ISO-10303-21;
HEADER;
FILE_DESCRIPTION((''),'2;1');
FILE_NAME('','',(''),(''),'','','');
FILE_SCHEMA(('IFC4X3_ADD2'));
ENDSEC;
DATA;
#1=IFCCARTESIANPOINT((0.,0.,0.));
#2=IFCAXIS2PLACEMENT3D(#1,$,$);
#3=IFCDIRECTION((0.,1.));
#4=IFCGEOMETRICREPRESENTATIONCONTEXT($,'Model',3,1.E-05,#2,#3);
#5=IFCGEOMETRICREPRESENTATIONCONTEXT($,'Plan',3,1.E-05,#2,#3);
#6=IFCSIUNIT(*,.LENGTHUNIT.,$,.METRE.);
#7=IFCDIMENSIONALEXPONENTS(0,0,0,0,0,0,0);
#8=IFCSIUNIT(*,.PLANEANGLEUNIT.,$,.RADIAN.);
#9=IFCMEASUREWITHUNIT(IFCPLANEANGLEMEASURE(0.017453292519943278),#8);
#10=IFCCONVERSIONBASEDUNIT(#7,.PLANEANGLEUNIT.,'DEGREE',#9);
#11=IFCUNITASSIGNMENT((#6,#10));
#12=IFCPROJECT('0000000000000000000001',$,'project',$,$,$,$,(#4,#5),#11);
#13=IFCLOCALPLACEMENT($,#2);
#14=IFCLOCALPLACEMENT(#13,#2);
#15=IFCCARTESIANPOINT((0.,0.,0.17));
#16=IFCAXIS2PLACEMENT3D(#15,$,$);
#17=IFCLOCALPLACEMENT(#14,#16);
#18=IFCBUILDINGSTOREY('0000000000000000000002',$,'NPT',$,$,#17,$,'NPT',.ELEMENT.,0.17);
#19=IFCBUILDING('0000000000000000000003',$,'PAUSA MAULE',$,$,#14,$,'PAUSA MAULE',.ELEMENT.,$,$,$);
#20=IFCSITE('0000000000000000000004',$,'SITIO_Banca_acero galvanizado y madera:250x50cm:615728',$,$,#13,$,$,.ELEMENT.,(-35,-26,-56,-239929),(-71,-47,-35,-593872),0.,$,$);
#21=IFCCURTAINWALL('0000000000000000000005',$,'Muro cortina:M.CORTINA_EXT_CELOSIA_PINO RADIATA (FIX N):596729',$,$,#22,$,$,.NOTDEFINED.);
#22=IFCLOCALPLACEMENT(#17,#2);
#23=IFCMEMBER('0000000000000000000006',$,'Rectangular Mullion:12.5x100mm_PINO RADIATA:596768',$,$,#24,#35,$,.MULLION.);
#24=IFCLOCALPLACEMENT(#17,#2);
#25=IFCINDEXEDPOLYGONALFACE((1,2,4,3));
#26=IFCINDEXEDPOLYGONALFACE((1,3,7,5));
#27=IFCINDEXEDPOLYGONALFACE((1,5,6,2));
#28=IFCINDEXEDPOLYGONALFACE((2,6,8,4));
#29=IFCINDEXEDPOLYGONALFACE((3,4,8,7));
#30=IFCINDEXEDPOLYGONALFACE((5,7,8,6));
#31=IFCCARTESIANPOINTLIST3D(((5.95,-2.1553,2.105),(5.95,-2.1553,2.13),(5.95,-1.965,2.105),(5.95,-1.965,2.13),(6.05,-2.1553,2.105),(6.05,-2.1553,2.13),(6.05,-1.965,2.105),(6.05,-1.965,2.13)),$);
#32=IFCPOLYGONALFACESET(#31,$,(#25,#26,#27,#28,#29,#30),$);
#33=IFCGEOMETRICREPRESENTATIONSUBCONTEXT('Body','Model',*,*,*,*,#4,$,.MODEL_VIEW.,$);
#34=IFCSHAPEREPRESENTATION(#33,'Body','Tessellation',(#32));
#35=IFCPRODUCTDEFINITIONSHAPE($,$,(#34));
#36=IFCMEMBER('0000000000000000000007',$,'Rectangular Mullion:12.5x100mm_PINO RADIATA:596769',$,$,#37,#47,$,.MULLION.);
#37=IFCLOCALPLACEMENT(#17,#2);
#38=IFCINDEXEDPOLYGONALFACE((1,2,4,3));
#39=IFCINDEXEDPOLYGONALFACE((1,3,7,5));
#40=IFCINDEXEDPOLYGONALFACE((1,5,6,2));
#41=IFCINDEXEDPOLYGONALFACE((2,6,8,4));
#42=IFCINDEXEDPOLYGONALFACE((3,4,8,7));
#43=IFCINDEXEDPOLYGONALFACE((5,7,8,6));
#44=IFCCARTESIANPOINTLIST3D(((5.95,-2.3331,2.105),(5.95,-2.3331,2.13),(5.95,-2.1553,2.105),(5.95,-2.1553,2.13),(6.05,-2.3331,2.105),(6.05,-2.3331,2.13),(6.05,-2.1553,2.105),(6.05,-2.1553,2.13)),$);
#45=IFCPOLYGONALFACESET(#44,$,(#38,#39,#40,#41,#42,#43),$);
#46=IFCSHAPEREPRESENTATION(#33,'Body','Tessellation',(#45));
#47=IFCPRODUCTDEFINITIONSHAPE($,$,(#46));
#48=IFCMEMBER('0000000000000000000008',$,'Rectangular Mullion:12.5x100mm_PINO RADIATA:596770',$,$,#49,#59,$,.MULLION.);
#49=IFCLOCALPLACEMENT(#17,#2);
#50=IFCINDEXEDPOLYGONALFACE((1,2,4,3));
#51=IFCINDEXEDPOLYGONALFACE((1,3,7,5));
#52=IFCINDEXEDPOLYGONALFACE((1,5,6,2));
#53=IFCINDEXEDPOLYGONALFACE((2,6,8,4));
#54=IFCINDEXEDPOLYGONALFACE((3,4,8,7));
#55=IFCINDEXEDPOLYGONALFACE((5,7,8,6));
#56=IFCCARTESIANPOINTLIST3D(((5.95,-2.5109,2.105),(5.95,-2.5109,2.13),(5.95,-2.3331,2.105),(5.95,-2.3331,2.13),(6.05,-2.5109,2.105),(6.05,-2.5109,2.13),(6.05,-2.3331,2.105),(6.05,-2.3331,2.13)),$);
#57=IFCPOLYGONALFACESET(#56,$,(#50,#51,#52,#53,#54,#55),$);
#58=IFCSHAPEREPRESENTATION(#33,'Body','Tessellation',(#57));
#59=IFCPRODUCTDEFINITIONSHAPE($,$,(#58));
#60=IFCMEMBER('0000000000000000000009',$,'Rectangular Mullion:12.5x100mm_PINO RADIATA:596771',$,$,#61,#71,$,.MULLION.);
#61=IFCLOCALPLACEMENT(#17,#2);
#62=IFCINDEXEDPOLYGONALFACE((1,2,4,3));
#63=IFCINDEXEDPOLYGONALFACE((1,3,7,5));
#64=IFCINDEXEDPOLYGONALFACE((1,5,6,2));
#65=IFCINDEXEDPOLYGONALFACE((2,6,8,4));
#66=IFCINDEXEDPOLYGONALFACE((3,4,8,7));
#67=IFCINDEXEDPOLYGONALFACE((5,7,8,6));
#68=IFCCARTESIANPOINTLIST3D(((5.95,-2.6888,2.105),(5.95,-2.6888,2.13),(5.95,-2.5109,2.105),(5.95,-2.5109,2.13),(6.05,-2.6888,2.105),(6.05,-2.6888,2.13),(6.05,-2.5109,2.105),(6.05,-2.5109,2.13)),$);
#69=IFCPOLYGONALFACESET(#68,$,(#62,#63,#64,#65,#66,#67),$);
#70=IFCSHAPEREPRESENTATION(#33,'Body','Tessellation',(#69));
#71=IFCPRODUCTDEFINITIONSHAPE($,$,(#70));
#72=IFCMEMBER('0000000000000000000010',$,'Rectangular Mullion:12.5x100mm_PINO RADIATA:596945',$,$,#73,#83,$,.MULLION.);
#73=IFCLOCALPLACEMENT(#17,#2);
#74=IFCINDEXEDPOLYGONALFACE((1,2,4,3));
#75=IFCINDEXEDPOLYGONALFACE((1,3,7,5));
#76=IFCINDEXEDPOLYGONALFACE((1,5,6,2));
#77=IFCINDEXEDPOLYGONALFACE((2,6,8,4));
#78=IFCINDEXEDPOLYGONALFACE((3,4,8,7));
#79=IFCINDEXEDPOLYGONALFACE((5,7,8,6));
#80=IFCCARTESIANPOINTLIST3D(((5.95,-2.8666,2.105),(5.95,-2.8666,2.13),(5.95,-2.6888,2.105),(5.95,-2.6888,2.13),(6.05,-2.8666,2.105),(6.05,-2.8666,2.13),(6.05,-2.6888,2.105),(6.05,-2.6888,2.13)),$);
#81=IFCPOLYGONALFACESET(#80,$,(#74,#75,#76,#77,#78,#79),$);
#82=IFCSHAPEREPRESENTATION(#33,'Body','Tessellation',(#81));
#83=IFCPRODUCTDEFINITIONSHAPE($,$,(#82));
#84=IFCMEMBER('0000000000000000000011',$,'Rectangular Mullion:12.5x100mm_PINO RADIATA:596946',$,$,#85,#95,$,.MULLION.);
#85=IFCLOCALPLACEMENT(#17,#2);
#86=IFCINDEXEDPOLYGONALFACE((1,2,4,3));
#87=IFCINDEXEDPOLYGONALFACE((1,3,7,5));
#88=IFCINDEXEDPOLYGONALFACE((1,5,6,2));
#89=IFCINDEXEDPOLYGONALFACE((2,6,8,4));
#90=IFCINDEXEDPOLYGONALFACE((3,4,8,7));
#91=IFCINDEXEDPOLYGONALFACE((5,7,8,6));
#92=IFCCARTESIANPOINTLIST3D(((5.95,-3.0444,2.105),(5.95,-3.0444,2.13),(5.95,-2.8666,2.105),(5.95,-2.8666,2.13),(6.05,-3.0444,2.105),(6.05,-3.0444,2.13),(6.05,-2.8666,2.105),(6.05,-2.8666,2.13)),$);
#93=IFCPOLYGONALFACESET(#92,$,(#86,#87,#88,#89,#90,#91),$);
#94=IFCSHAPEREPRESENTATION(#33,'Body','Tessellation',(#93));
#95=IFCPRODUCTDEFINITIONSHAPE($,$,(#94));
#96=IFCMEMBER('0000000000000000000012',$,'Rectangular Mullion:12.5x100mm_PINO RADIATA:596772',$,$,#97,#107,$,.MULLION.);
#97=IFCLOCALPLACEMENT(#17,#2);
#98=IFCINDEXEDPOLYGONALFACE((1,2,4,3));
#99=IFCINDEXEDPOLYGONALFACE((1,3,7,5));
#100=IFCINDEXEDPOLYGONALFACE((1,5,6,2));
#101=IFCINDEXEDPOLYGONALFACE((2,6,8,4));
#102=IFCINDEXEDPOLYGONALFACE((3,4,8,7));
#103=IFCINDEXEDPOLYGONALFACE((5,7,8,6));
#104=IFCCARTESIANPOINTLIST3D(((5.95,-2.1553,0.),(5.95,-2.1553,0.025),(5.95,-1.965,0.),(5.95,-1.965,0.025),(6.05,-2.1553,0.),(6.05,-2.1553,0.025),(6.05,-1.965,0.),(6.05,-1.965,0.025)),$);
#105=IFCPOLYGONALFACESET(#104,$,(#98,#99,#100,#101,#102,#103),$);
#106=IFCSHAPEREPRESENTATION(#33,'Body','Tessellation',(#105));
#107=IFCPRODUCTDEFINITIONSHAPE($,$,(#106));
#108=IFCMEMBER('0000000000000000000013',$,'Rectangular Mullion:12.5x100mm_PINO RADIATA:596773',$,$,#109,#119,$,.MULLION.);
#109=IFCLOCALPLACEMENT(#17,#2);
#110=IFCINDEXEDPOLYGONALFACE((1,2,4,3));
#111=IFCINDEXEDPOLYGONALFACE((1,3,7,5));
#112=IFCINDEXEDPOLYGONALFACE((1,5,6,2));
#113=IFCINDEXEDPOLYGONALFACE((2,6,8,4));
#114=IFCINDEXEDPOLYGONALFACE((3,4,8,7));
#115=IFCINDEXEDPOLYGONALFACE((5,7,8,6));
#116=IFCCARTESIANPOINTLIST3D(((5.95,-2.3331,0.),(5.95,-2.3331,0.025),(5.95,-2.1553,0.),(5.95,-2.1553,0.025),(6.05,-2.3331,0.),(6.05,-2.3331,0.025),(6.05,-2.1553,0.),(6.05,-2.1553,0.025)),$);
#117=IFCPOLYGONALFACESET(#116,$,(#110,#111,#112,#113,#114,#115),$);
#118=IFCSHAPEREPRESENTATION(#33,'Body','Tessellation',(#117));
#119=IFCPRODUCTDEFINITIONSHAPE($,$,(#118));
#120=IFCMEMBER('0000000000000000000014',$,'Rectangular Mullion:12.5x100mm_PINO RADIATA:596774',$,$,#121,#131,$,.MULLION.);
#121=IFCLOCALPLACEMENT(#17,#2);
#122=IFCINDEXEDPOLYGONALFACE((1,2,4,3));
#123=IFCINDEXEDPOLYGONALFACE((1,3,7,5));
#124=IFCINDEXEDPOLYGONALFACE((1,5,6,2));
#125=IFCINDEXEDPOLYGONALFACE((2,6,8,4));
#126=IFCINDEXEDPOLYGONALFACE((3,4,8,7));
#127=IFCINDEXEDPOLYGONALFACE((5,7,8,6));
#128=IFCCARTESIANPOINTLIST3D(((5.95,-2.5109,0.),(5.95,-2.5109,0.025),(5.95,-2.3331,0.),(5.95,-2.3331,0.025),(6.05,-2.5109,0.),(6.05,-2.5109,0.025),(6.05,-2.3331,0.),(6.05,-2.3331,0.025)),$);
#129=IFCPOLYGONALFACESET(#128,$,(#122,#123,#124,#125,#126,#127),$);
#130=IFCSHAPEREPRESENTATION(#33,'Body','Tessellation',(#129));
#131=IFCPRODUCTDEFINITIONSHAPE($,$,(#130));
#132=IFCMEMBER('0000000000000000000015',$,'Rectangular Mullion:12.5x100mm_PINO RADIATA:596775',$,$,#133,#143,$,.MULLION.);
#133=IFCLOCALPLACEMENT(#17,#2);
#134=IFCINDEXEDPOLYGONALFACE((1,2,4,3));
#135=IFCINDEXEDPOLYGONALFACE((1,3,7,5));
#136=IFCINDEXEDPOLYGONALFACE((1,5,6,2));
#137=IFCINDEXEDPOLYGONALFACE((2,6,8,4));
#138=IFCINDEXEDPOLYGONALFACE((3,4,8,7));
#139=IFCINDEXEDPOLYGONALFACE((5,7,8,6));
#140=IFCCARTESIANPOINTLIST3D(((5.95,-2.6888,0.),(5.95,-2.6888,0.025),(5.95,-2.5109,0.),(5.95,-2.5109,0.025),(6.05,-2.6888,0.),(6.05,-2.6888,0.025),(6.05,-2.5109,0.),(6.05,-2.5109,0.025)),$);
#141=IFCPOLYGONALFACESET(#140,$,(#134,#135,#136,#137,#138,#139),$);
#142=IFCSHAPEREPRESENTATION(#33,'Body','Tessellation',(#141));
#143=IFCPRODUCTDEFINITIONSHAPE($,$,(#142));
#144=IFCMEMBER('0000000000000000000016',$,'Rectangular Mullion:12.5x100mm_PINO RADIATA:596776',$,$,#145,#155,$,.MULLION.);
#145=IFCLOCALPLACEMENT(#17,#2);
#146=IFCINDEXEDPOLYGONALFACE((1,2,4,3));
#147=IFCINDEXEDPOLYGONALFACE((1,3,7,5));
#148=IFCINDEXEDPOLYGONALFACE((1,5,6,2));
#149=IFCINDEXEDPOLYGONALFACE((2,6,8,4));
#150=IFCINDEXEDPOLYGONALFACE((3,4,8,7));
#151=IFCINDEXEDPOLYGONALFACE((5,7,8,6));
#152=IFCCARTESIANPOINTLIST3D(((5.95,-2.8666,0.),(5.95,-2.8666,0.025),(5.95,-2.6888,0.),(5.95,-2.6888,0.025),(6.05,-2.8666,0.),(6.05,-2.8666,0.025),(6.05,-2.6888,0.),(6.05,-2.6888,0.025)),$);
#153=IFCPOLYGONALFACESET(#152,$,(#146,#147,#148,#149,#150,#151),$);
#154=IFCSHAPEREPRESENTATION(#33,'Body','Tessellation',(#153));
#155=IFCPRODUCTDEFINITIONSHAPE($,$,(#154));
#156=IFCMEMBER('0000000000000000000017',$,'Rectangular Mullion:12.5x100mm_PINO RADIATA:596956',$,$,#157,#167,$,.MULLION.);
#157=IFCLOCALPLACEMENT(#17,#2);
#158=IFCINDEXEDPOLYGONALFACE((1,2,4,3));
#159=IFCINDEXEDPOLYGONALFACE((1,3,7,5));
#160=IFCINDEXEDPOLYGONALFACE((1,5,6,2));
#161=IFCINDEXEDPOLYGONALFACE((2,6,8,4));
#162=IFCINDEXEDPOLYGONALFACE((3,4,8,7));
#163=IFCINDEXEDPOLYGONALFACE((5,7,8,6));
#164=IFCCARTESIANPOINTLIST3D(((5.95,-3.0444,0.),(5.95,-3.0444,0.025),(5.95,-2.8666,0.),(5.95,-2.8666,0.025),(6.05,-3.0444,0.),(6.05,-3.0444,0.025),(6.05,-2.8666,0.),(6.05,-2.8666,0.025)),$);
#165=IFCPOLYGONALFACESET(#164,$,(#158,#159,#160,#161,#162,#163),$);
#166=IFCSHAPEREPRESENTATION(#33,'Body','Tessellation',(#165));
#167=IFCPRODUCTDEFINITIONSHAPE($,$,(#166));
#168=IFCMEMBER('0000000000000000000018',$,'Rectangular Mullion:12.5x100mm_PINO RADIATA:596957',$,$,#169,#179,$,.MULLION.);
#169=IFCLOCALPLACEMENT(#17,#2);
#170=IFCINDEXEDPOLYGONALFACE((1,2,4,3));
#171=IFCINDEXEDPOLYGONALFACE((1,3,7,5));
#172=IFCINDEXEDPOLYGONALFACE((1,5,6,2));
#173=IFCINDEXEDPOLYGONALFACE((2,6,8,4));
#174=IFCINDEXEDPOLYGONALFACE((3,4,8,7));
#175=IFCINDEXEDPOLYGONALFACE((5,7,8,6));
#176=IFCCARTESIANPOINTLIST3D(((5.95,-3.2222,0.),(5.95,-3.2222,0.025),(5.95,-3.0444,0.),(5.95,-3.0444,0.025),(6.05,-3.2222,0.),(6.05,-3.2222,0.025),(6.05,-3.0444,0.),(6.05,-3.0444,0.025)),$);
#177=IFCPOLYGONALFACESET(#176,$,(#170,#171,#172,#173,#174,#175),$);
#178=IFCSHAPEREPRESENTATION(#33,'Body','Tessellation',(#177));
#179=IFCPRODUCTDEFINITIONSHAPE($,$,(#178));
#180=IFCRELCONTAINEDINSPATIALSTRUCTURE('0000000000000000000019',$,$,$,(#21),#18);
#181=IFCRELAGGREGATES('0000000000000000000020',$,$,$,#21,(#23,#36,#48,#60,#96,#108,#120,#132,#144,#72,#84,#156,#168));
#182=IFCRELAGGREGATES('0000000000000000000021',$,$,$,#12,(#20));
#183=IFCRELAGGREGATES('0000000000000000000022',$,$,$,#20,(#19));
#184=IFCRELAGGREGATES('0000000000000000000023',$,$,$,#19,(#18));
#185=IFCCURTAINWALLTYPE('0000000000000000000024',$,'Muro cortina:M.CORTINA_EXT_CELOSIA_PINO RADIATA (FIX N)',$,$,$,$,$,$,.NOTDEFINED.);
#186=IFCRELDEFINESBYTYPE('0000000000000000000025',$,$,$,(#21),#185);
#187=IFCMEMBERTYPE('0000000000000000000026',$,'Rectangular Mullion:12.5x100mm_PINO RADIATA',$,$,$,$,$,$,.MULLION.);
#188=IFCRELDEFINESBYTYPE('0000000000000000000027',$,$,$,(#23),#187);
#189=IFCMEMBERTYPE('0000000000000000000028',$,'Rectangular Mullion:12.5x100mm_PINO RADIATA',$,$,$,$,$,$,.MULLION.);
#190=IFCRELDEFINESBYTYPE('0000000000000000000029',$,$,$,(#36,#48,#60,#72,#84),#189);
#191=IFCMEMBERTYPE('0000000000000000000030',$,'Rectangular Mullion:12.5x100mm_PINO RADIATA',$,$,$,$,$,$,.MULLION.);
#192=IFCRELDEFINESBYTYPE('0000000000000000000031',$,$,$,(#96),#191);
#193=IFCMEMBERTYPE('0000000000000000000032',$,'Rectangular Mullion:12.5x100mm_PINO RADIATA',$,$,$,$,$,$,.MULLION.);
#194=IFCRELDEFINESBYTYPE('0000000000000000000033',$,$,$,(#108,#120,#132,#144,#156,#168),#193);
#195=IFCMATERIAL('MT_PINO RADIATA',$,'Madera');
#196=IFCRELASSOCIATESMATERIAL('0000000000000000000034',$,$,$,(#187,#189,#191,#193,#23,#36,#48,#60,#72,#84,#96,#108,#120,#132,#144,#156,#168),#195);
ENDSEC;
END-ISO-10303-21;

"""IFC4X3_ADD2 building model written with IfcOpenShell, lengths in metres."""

from ifc_helpers import new_model, entity, si_unit, converted_unit, direction, frame, frame_2d, origin, place, context, subcontext, project, spatial, rectangle, extrude, source, transform, mapped, material, material_profile, profile_set, profile_usage, type_object, type_shapes, element, aggregate, save


model = new_model("IFC4X3_ADD2")

# Units and contexts
model_context = context("Model", 3, precision=1e-05, world=origin(), true_north=direction((0.0, 1.0)))
plan_context = context("Plan", 3, precision=1e-05, world=origin(), true_north=direction((0.0, 1.0)))
body_context = subcontext(model_context, "Body", "Model", "MODEL_VIEW")
ifc_project = project(units=[si_unit("LENGTHUNIT", "METRE"), converted_unit("PLANEANGLEUNIT", "DEGREE", entity("IfcPlaneAngleMeasure", 0.017453292519943278), si_unit("PLANEANGLEUNIT", "RADIAN"), dimensions=[0, 0, 0, 0, 0, 0, 0])], contexts=[model_context, plan_context])

# Site, building, storey
site_placement = place(None, origin())
site = spatial("IfcSite", under=ifc_project, at=site_placement, Name="SITIO_Banca_acero galvanizado y madera:250x50cm:615728", CompositionType="ELEMENT", RefLatitude=(-35, -26, -56, -239929), RefLongitude=(-71, -47, -35, -593872), RefElevation=0.0)
building_placement = place(site_placement, origin())
building = spatial("IfcBuilding", under=site, at=building_placement, Name="PAUSA MAULE", LongName="PAUSA MAULE", CompositionType="ELEMENT")
storey_placement = place(building_placement, frame((0.0, 0.0, 0.17)))
storey = spatial("IfcBuildingStorey", under=building, at=storey_placement, Name="NPT", LongName="NPT", CompositionType="ELEMENT", Elevation=0.17)

# Curtain wall, members
curtain_wall_type = type_object("IfcCurtainWallType", Name="Muro cortina:M.CORTINA_EXT_CELOSIA_PINO RADIATA (FIX N)", PredefinedType="NOTDEFINED")
curtain_wall_placement = place(storey_placement, frame((0.0, 0.0, -0.17)))
curtain_wall = element("IfcCurtainWall", 1, at=curtain_wall_placement, inside=storey, type_object=curtain_wall_type, Name="Muro cortina:M.CORTINA_EXT_CELOSIA_PINO RADIATA (FIX N):596729", PredefinedType="NOTDEFINED")
ifc_material = material(Name="MT_PINO RADIATA", Category="Madera")
ifc_material_profile = material_profile(ifc_material, rectangle(XDim=0.025, YDim=0.1, at=frame_2d((0.0, 0.0), x_axis=(1.0, 0.0))), Name="12.5x100mm_PINO RADIATA")
ifc_profile_set = profile_set([ifc_material_profile], Name="12.5x100mm_PINO RADIATA")
ifc_profile_usage = profile_usage(ifc_profile_set)
member_type_1 = type_object("IfcMemberType", Name="Rectangular Mullion:12.5x100mm_PINO RADIATA", PredefinedType="MULLION", material=ifc_profile_set)
shared_shape_1 = source(origin(), body_context, "Body", "SweptSolid", [
    extrude(rectangle(XDim=0.025, YDim=0.1, at=frame_2d((0.0, 0.0), x_axis=(1.0, 0.0))), frame((-0.0125, 0.0, -0.1903), z_axis=(0.0, 0.0, 1.0), x_axis=(-1.0, 0.0, 0.0)), (0.0, 0.0, 1.0), 0.1903),
])
type_shapes(member_type_1, [shared_shape_1])
member_1_placement = place(curtain_wall_placement, frame((6.0, -2.1553, 2.3), z_axis=(0.0, -1.0, 0.0), x_axis=(0.0, 0.0, 1.0)))
member_1 = element("IfcMember", 2, at=member_1_placement, type_object=member_type_1, material=ifc_profile_usage, Name="Rectangular Mullion:12.5x100mm_PINO RADIATA:596768", PredefinedType="MULLION", context=body_context, shape_type="MappedRepresentation", body=[
    mapped(shared_shape_1, transform((0.0, 0.0, 0.0), scale=1.0)),
])
member_type_2 = type_object("IfcMemberType", Name="Rectangular Mullion:12.5x100mm_PINO RADIATA", PredefinedType="MULLION", material=ifc_profile_set)
shared_shape_2 = source(origin(), body_context, "Body", "SweptSolid", [
    extrude(rectangle(XDim=0.025, YDim=0.1, at=frame_2d((0.0, 0.0), x_axis=(1.0, 0.0))), frame((-0.0125, 0.0, -0.1778), z_axis=(0.0, 0.0, 1.0), x_axis=(-1.0, 0.0, 0.0)), (0.0, 0.0, 1.0), 0.1778),
])
type_shapes(member_type_2, [shared_shape_2])
member_2_placement = place(curtain_wall_placement, frame((6.0, -2.3331, 2.3), z_axis=(0.0, -1.0, 0.0), x_axis=(0.0, 0.0, 1.0)))
member_2 = element("IfcMember", 3, at=member_2_placement, type_object=member_type_2, material=ifc_profile_usage, Name="Rectangular Mullion:12.5x100mm_PINO RADIATA:596769", PredefinedType="MULLION", context=body_context, shape_type="MappedRepresentation", body=[
    mapped(shared_shape_2, transform((0.0, 0.0, 0.0), scale=1.0)),
])
member_3_placement = place(curtain_wall_placement, frame((6.0, -2.5109, 2.3), z_axis=(0.0, -1.0, 0.0), x_axis=(0.0, 0.0, 1.0)))
member_3 = element("IfcMember", 4, at=member_3_placement, type_object=member_type_2, material=ifc_profile_usage, Name="Rectangular Mullion:12.5x100mm_PINO RADIATA:596770", PredefinedType="MULLION", context=body_context, shape_type="MappedRepresentation", body=[
    mapped(shared_shape_2, transform((0.0, 0.0, 0.0), scale=1.0)),
])
member_4_placement = place(curtain_wall_placement, frame((6.0, -2.6888, 2.3), z_axis=(0.0, -1.0, 0.0), x_axis=(0.0, 0.0, 1.0)))
member_4 = element("IfcMember", 5, at=member_4_placement, type_object=member_type_2, material=ifc_profile_usage, Name="Rectangular Mullion:12.5x100mm_PINO RADIATA:596771", PredefinedType="MULLION", context=body_context, shape_type="MappedRepresentation", body=[
    mapped(shared_shape_2, transform((0.0, 0.0, 0.0), scale=1.0)),
])
member_5_placement = place(curtain_wall_placement, frame((6.0, -2.8666, 2.3), z_axis=(0.0, -1.0, 0.0), x_axis=(0.0, 0.0, 1.0)))
member_5 = element("IfcMember", 6, at=member_5_placement, type_object=member_type_2, material=ifc_profile_usage, Name="Rectangular Mullion:12.5x100mm_PINO RADIATA:596945", PredefinedType="MULLION", context=body_context, shape_type="MappedRepresentation", body=[
    mapped(shared_shape_2, transform((0.0, 0.0, 0.0), scale=1.0)),
])
member_6_placement = place(curtain_wall_placement, frame((6.0, -3.0444, 2.3), z_axis=(0.0, -1.0, 0.0), x_axis=(0.0, 0.0, 1.0)))
member_6 = element("IfcMember", 7, at=member_6_placement, type_object=member_type_2, material=ifc_profile_usage, Name="Rectangular Mullion:12.5x100mm_PINO RADIATA:596946", PredefinedType="MULLION", context=body_context, shape_type="MappedRepresentation", body=[
    mapped(shared_shape_2, transform((0.0, 0.0, 0.0), scale=1.0)),
])
member_type_3 = type_object("IfcMemberType", Name="Rectangular Mullion:12.5x100mm_PINO RADIATA", PredefinedType="MULLION", material=ifc_profile_set)
shared_shape_3 = source(origin(), body_context, "Body", "SweptSolid", [
    extrude(rectangle(XDim=0.025, YDim=0.1, at=frame_2d((0.0, 0.0), x_axis=(1.0, 0.0))), frame((-0.0125, 0.0, -0.1903), z_axis=(0.0, 0.0, 1.0), x_axis=(-1.0, 0.0, 0.0)), (0.0, 0.0, 1.0), 0.1903),
])
type_shapes(member_type_3, [shared_shape_3])
member_7_placement = place(curtain_wall_placement, frame((6.0, -1.965, 0.17), z_axis=(0.0, 1.0, 0.0), x_axis=(0.0, 0.0, -1.0)))
member_7 = element("IfcMember", 8, at=member_7_placement, type_object=member_type_3, material=ifc_profile_usage, Name="Rectangular Mullion:12.5x100mm_PINO RADIATA:596772", PredefinedType="MULLION", context=body_context, shape_type="MappedRepresentation", body=[
    mapped(shared_shape_3, transform((0.0, 0.0, 0.0), scale=1.0)),
])
member_type_4 = type_object("IfcMemberType", Name="Rectangular Mullion:12.5x100mm_PINO RADIATA", PredefinedType="MULLION", material=ifc_profile_set)
shared_shape_4 = source(origin(), body_context, "Body", "SweptSolid", [
    extrude(rectangle(XDim=0.025, YDim=0.1, at=frame_2d((0.0, 0.0), x_axis=(1.0, 0.0))), frame((-0.0125, 0.0, -0.1778), z_axis=(0.0, 0.0, 1.0), x_axis=(-1.0, 0.0, 0.0)), (0.0, 0.0, 1.0), 0.1778),
])
type_shapes(member_type_4, [shared_shape_4])
member_8_placement = place(curtain_wall_placement, frame((6.0, -2.1553, 0.17), z_axis=(0.0, 1.0, 0.0), x_axis=(0.0, 0.0, -1.0)))
member_8 = element("IfcMember", 9, at=member_8_placement, type_object=member_type_4, material=ifc_profile_usage, Name="Rectangular Mullion:12.5x100mm_PINO RADIATA:596773", PredefinedType="MULLION", context=body_context, shape_type="MappedRepresentation", body=[
    mapped(shared_shape_4, transform((0.0, 0.0, 0.0), scale=1.0)),
])
member_9_placement = place(curtain_wall_placement, frame((6.0, -2.3331, 0.17), z_axis=(0.0, 1.0, 0.0), x_axis=(0.0, 0.0, -1.0)))
member_9 = element("IfcMember", 10, at=member_9_placement, type_object=member_type_4, material=ifc_profile_usage, Name="Rectangular Mullion:12.5x100mm_PINO RADIATA:596774", PredefinedType="MULLION", context=body_context, shape_type="MappedRepresentation", body=[
    mapped(shared_shape_4, transform((0.0, 0.0, 0.0), scale=1.0)),
])
member_10_placement = place(curtain_wall_placement, frame((6.0, -2.5109, 0.17), z_axis=(0.0, 1.0, 0.0), x_axis=(0.0, 0.0, -1.0)))
member_10 = element("IfcMember", 11, at=member_10_placement, type_object=member_type_4, material=ifc_profile_usage, Name="Rectangular Mullion:12.5x100mm_PINO RADIATA:596775", PredefinedType="MULLION", context=body_context, shape_type="MappedRepresentation", body=[
    mapped(shared_shape_4, transform((0.0, 0.0, 0.0), scale=1.0)),
])
member_11_placement = place(curtain_wall_placement, frame((6.0, -2.6888, 0.17), z_axis=(0.0, 1.0, 0.0), x_axis=(0.0, 0.0, -1.0)))
member_11 = element("IfcMember", 12, at=member_11_placement, type_object=member_type_4, material=ifc_profile_usage, Name="Rectangular Mullion:12.5x100mm_PINO RADIATA:596776", PredefinedType="MULLION", context=body_context, shape_type="MappedRepresentation", body=[
    mapped(shared_shape_4, transform((0.0, 0.0, 0.0), scale=1.0)),
])
member_12_placement = place(curtain_wall_placement, frame((6.0, -2.8666, 0.17), z_axis=(0.0, 1.0, 0.0), x_axis=(0.0, 0.0, -1.0)))
member_12 = element("IfcMember", 13, at=member_12_placement, type_object=member_type_4, material=ifc_profile_usage, Name="Rectangular Mullion:12.5x100mm_PINO RADIATA:596956", PredefinedType="MULLION", context=body_context, shape_type="MappedRepresentation", body=[
    mapped(shared_shape_4, transform((0.0, 0.0, 0.0), scale=1.0)),
])
member_13_placement = place(curtain_wall_placement, frame((6.0, -3.0444, 0.17), z_axis=(0.0, 1.0, 0.0), x_axis=(0.0, 0.0, -1.0)))
member_13 = element("IfcMember", 14, at=member_13_placement, type_object=member_type_4, material=ifc_profile_usage, Name="Rectangular Mullion:12.5x100mm_PINO RADIATA:596957", PredefinedType="MULLION", context=body_context, shape_type="MappedRepresentation", body=[
    mapped(shared_shape_4, transform((0.0, 0.0, 0.0), scale=1.0)),
])
aggregate(curtain_wall, [member_1, member_2, member_3, member_4, member_7, member_8, member_9, member_10, member_11, member_5, member_6, member_12, member_13])

save(model, "model.ifc")
